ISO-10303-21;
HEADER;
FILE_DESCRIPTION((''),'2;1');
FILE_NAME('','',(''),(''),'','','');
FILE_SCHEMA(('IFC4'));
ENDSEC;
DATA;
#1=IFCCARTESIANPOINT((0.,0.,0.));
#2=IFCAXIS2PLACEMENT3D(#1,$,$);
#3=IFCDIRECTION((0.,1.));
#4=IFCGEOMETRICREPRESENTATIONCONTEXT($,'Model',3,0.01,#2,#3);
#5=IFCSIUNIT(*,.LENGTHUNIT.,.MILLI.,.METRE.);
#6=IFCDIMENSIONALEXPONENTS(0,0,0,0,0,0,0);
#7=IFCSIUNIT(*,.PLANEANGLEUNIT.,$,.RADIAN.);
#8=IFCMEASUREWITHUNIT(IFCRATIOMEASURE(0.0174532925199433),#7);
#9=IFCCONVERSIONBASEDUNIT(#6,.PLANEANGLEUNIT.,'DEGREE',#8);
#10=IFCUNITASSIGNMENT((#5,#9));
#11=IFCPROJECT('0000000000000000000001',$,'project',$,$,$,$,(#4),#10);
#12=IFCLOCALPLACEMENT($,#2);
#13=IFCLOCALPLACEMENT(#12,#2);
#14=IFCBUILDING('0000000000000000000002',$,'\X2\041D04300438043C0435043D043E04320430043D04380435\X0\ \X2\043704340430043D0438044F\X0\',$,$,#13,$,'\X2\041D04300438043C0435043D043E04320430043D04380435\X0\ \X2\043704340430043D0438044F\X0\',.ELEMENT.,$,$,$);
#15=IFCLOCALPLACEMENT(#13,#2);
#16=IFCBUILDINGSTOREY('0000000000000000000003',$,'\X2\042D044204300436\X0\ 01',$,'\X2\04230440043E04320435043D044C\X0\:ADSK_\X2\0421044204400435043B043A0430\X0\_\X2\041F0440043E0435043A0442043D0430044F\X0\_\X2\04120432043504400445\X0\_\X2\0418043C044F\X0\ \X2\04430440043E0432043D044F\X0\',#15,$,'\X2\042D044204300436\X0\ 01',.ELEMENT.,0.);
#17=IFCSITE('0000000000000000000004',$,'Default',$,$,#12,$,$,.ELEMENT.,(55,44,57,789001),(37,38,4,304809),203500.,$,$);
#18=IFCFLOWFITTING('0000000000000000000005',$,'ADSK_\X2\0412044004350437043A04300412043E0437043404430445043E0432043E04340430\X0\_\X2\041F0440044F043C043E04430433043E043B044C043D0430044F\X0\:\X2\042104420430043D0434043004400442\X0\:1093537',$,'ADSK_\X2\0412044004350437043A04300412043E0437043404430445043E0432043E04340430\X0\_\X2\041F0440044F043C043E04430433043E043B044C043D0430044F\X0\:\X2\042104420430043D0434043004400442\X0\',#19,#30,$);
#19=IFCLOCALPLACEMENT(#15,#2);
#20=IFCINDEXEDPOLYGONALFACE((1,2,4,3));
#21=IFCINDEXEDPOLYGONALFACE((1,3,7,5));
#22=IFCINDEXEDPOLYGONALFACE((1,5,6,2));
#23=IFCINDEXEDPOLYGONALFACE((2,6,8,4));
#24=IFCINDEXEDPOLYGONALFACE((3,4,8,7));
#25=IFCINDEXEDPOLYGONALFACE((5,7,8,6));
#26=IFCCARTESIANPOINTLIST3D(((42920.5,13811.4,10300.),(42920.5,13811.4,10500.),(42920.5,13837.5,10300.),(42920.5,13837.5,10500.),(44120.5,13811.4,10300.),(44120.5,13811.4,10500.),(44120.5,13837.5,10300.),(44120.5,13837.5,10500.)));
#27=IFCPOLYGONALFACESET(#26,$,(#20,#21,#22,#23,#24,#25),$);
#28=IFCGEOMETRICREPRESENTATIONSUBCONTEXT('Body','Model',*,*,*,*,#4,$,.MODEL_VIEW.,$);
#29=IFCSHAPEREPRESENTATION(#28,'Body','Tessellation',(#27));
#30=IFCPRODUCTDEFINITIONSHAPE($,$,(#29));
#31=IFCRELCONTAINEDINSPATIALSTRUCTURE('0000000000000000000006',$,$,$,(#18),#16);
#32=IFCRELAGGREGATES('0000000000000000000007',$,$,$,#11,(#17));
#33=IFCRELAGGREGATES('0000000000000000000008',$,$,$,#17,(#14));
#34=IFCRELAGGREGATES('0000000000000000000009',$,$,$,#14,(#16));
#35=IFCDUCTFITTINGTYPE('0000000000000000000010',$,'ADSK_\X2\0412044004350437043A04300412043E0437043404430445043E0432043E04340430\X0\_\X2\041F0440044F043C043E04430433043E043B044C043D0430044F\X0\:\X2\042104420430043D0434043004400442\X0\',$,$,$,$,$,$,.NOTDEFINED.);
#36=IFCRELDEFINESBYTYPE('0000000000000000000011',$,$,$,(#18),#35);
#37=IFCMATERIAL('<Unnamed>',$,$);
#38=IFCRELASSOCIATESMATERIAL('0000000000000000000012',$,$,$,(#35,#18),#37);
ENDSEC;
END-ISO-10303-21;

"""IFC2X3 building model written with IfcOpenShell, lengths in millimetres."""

from ifc_helpers import new_model, entity, si_unit, converted_unit, direction, frame, frame_2d, origin, place, context, subcontext, project, spatial, rectangle, extrude, source, transform, mapped, material, type_object, type_shapes, element, save


model = new_model("IFC2X3")

# Units and contexts
model_context = context("Model", 3, precision=0.01, world=origin(), true_north=direction((0.0, 1.0)))
body_context = subcontext(model_context, "Body", "Model", "MODEL_VIEW")
ifc_project = project(units=[si_unit("LENGTHUNIT", "METRE", prefix="MILLI"), converted_unit("PLANEANGLEUNIT", "DEGREE", entity("IfcRatioMeasure", 0.0174532925199433), si_unit("PLANEANGLEUNIT", "RADIAN"), dimensions=[0, 0, 0, 0, 0, 0, 0])], contexts=[model_context])

# Site, building, storey
site_placement = place(None, frame((0.0, 0.0, 0.0)))
site = spatial("IfcSite", under=ifc_project, at=site_placement, Name="Default", CompositionType="ELEMENT", RefLatitude=(55, 44, 57, 789001), RefLongitude=(37, 38, 4, 304809), RefElevation=203500.0)
building_placement = place(site_placement, origin())
building = spatial("IfcBuilding", under=site, at=building_placement, Name="Наименование здания", LongName="Наименование здания", CompositionType="ELEMENT")
storey_placement = place(building_placement, origin())
storey = spatial("IfcBuildingStorey", under=building, at=storey_placement, Name="Этаж 01", ObjectType="Уровень:ADSK_Стрелка_Проектная_Вверх_Имя уровня", LongName="Этаж 01", CompositionType="ELEMENT", Elevation=0.0)

# Shared definitions
ifc_material_1 = material(Name="<Unnamed>")

# Flow fitting
duct_fitting_type_1 = type_object("IfcDuctFittingType", Name="ADSK_ВрезкаВоздуховода_Прямоугольная:Стандарт", PredefinedType="NOTDEFINED", material=ifc_material_1)
shared_shape_1 = source(origin(), body_context, "Body", "SweptSolid", [
    extrude(rectangle(XDim=26.1, YDim=1200.0, at=frame_2d((0.0, 0.0), x_axis=(1.0, 0.0))), frame((7.0, 0.0, -100.0)), (0.0, 0.0, 1.0), 200.0),
])
type_shapes(duct_fitting_type_1, [shared_shape_1])
flow_fitting_1_placement = place(storey_placement, frame((43520.5, 13817.5, 10400.0), z_axis=(0.0, 0.0, -1.0), x_axis=(0.0, 1.0, 0.0)))
element("IfcFlowFitting", 1, at=flow_fitting_1_placement, inside=storey, type_object=duct_fitting_type_1, material=ifc_material_1, Name="ADSK_ВрезкаВоздуховода_Прямоугольная:Стандарт:1093537", ObjectType="ADSK_ВрезкаВоздуховода_Прямоугольная:Стандарт", context=body_context, shape_type="MappedRepresentation", body=[
    mapped(shared_shape_1, transform((0.0, 0.0, 0.0), scale=1.0)),
])

save(model, "model.ifc")
